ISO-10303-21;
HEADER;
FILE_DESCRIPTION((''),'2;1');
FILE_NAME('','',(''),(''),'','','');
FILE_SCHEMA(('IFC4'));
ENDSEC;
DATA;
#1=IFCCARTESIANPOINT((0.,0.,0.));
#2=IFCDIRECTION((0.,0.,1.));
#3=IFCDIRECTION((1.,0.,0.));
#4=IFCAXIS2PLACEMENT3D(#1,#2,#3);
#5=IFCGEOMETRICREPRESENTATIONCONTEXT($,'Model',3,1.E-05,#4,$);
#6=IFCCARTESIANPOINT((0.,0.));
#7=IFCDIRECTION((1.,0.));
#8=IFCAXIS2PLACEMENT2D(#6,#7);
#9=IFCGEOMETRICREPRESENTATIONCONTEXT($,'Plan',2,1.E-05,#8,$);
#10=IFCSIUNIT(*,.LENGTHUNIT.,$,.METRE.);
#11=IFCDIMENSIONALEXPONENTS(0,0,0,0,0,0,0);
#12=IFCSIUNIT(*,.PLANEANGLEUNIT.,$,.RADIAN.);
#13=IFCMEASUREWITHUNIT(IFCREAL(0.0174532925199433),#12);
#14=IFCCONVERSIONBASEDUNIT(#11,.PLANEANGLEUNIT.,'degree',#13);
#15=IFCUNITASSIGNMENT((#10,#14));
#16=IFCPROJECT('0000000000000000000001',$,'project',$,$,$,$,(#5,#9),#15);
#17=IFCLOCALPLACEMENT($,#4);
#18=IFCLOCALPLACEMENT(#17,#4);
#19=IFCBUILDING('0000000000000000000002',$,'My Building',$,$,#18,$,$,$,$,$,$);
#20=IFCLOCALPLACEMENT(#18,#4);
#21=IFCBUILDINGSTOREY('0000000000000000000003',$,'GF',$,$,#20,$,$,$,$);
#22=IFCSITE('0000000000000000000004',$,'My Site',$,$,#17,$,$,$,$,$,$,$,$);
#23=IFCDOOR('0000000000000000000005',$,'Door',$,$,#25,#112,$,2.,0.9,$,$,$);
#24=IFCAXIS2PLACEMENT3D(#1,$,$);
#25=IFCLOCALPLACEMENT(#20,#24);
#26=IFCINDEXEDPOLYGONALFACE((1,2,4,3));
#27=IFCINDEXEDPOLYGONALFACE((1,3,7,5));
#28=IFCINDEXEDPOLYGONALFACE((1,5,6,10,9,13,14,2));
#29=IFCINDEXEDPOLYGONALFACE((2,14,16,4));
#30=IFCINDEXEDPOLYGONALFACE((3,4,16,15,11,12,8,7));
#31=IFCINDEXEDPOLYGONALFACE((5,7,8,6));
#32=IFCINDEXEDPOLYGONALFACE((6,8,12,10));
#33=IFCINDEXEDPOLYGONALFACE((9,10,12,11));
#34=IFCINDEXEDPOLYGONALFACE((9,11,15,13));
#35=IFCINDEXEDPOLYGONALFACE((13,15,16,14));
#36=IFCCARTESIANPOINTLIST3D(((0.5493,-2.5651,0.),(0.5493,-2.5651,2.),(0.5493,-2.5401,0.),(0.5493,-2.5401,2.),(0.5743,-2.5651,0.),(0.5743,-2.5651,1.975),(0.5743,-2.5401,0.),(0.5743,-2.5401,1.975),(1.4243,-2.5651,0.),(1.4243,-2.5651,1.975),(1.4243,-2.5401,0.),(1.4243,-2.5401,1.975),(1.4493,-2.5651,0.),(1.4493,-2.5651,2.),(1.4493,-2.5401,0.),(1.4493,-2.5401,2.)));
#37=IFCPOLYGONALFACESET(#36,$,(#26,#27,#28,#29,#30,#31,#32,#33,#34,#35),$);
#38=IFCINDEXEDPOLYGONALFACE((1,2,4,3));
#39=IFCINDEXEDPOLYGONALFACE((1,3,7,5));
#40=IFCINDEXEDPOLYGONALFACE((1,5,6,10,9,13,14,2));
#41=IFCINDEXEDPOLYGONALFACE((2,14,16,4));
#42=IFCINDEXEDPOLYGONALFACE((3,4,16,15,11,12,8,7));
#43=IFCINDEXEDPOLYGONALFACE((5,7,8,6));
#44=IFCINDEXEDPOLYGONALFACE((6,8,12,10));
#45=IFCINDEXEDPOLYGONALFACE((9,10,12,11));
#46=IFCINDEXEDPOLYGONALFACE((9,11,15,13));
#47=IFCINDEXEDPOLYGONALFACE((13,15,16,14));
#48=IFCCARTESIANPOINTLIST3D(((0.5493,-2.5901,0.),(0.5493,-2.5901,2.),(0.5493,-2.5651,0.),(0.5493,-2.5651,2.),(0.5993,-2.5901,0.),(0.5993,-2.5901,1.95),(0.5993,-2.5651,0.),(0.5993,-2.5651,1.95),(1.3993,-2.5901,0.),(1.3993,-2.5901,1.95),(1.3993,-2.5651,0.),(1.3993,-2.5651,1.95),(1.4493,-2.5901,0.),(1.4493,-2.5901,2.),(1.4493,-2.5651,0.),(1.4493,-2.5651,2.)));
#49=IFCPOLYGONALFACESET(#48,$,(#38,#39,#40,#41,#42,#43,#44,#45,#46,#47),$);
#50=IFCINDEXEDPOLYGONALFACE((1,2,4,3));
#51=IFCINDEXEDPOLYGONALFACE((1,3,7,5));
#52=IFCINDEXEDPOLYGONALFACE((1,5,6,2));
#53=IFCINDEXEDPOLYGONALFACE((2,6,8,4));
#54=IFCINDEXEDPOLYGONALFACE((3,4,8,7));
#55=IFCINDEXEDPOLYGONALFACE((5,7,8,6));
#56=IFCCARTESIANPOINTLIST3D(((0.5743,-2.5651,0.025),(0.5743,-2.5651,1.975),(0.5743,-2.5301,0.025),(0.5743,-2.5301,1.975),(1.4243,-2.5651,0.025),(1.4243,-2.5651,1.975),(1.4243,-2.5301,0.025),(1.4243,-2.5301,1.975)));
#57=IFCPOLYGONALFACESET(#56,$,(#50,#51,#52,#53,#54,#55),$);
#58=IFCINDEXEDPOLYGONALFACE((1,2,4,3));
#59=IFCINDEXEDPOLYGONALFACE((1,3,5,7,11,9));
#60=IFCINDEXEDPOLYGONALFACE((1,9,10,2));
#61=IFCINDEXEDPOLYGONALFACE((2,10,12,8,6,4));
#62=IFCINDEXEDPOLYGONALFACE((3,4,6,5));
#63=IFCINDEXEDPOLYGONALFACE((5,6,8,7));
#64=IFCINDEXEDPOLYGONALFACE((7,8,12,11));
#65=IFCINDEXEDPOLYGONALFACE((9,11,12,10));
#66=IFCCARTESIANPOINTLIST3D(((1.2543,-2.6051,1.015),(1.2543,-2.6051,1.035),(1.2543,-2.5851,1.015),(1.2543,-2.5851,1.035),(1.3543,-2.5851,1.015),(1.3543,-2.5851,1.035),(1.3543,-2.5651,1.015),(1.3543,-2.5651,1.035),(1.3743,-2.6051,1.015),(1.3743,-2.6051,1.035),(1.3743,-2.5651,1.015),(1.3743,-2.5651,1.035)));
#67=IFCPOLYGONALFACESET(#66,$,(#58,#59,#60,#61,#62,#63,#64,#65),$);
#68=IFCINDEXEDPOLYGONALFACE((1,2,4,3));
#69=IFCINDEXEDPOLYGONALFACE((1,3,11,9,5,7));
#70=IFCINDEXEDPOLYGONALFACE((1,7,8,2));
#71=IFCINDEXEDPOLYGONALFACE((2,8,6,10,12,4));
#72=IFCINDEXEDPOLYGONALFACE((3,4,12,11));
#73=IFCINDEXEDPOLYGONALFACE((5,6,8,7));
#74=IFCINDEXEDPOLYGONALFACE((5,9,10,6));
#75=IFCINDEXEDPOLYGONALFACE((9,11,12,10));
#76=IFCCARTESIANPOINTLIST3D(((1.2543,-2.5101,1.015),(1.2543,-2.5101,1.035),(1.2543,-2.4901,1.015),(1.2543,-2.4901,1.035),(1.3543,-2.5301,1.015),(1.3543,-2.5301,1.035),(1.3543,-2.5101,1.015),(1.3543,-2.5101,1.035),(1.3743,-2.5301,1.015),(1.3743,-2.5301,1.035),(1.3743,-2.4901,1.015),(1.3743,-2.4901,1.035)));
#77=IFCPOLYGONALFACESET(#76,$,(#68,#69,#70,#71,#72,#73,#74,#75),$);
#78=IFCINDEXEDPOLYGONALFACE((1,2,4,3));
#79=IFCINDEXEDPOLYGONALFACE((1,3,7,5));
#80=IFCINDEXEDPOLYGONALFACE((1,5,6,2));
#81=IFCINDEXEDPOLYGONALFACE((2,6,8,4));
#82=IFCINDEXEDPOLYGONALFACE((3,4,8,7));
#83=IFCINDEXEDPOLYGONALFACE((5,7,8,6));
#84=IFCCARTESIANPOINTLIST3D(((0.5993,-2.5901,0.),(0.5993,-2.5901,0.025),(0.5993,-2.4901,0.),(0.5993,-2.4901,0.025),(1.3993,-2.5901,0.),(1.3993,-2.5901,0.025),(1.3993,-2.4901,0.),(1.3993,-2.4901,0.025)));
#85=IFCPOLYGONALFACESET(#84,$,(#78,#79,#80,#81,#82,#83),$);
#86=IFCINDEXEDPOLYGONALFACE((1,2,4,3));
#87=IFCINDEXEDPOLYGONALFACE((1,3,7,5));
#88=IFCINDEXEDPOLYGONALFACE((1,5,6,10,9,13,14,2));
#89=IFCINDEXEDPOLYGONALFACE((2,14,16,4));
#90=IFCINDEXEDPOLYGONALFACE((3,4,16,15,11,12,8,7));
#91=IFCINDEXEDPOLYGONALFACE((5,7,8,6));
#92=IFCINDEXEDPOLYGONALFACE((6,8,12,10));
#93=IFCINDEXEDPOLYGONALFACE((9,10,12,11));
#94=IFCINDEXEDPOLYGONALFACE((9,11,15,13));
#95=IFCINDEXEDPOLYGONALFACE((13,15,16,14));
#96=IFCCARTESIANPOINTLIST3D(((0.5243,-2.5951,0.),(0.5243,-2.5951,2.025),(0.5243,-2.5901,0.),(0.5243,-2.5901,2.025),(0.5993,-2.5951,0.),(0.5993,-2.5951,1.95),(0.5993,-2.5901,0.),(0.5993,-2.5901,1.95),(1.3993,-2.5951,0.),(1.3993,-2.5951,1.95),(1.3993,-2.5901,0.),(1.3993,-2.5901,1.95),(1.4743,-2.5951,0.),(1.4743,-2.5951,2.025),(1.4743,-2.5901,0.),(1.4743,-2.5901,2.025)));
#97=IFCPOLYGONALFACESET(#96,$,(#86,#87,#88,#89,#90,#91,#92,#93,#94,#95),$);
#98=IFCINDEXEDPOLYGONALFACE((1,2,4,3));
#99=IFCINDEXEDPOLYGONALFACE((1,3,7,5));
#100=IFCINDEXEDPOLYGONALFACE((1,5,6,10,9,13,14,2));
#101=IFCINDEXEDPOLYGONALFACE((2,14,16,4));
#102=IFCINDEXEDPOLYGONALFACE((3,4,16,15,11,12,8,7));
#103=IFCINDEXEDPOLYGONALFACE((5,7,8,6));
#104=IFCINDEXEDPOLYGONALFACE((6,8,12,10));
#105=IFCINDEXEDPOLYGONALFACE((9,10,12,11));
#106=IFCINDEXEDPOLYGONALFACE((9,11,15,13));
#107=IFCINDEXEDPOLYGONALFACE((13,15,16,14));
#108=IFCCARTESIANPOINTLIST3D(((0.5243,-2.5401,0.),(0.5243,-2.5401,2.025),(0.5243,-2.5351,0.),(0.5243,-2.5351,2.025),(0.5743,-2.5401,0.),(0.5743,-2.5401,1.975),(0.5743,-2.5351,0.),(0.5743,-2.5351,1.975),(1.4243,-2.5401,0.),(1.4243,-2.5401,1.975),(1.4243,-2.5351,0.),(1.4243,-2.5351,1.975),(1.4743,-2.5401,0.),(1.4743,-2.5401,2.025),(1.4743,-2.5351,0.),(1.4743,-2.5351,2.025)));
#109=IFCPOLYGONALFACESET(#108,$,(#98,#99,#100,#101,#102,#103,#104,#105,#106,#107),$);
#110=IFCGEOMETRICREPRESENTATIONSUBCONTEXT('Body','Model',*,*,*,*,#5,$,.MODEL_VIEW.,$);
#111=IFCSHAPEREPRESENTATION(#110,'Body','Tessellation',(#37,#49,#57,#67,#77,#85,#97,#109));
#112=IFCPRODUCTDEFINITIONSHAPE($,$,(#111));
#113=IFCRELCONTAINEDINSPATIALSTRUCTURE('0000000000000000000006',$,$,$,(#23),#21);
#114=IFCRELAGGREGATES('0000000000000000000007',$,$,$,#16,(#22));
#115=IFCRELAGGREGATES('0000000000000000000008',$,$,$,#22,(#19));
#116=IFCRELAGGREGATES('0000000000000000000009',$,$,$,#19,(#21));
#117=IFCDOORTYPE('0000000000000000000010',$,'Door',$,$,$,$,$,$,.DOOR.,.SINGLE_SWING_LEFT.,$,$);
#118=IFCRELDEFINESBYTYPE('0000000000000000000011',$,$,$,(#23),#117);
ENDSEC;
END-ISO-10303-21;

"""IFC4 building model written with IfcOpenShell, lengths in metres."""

from ifc_helpers import new_model, entity, si_unit, converted_unit, frame, origin_with_axes, origin_2d_with_axis, place, context, subcontext, project, spatial, line, indexed_curve, outline, extrude, shape, source, transform, mapped, type_object, type_shapes, element, save


model = new_model("IFC4")

# Units and contexts
model_context = context("Model", 3, precision=1e-05, world=origin_with_axes())
plan_context = context("Plan", 2, precision=1e-05, world=origin_2d_with_axis())
body_context_1 = subcontext(model_context, "Body", "Model", "MODEL_VIEW")
body_context_2 = subcontext(plan_context, "Body", "Plan", "PLAN_VIEW")
ifc_project = project(units=[si_unit("LENGTHUNIT", "METRE"), converted_unit("PLANEANGLEUNIT", "degree", entity("IfcReal", 0.0174532925199433), si_unit("PLANEANGLEUNIT", "RADIAN"), dimensions=[0, 0, 0, 0, 0, 0, 0])], contexts=[model_context, plan_context])

# Site, building, storey
site_placement = place(None, origin_with_axes())
site = spatial("IfcSite", under=ifc_project, at=site_placement, Name="My Site")
building_placement = place(site_placement, origin_with_axes())
building = spatial("IfcBuilding", under=site, at=building_placement, Name="My Building")
storey_placement = place(building_placement, origin_with_axes())
storey = spatial("IfcBuildingStorey", under=building, at=storey_placement, Name="GF")

# Shared definitions
door_type = type_object("IfcDoorType", Name="Door", OperationType="SINGLE_SWING_LEFT", PredefinedType="DOOR")
shared_shape_1 = source(origin_with_axes(), body_context_1, "Body", "SweptSolid", [
    extrude(outline(indexed_curve([(0.0, 0.0), (0.0, 2.0), (0.9, 2.0), (0.9, 0.0), (0.875, 0.0), (0.875, 1.975), (0.025, 1.975), (0.025, 0.0)], segments=[line(1, 2, 3, 4, 5, 6, 7, 8, 1)])), frame((0.0, 0.025, 0.0), z_axis=(0.0, -1.0, 0.0), x_axis=(1.0, 0.0, 0.0)), (0.0, 0.0, -1.0), 0.025),
    extrude(outline(indexed_curve([(0.0, 0.0), (0.0, 2.0), (0.9, 2.0), (0.9, 0.0), (0.85, 0.0), (0.85, 1.95), (0.05, 1.95), (0.05, 0.0)], segments=[line(1, 2, 3, 4, 5, 6, 7, 8, 1)])), frame((0.0, 0.0, 0.0), z_axis=(0.0, -1.0, 0.0), x_axis=(1.0, 0.0, 0.0)), (0.0, 0.0, -1.0), 0.025),
    extrude(outline(indexed_curve([(0.0, 0.0), (0.85, 0.0), (0.85, 0.035), (0.0, 0.035)], segments=[line(1, 2, 3, 4, 1)])), frame((0.025, 0.025, 0.025), z_axis=(0.0, 0.0, 1.0), x_axis=(1.0, 0.0, 0.0)), (0.0, 0.0, 1.0), 1.95),
    extrude(outline(indexed_curve([(0.0, 0.0), (0.0, -0.04), (-0.12, -0.04), (-0.12, -0.02), (-0.02, -0.02), (-0.02, 0.0)], segments=[line(1, 2, 3, 4, 5, 6, 1)])), frame((0.825, 0.025, 1.015), z_axis=(0.0, 0.0, 1.0), x_axis=(1.0, 0.0, 0.0)), (0.0, 0.0, 1.0), 0.02),
    extrude(outline(indexed_curve([(0.0, 0.0), (0.0, 0.04), (-0.12, 0.04), (-0.12, 0.02), (-0.02, 0.02), (-0.02, 0.0)], segments=[line(1, 2, 3, 4, 5, 6, 1)])), frame((0.825, 0.06, 1.015), z_axis=(0.0, 0.0, 1.0), x_axis=(1.0, 0.0, 0.0)), (0.0, 0.0, 1.0), 0.02),
    extrude(outline(indexed_curve([(0.0, 0.0), (0.8, 0.0), (0.8, 0.1), (0.0, 0.1)], segments=[line(1, 2, 3, 4, 1)])), frame((0.05, 0.0, 0.0), z_axis=(0.0, 0.0, 1.0), x_axis=(1.0, 0.0, 0.0)), (0.0, 0.0, 1.0), 0.025),
    extrude(outline(indexed_curve([(0.0, 0.0), (0.0, 2.025), (0.95, 2.025), (0.95, 0.0), (0.875, 0.0), (0.875, 1.95), (0.075, 1.95), (0.075, 0.0)], segments=[line(1, 2, 3, 4, 5, 6, 7, 8, 1)])), frame((-0.025, -0.005, 0.0), z_axis=(0.0, -1.0, 0.0), x_axis=(1.0, 0.0, 0.0)), (0.0, 0.0, -1.0), 0.005),
    extrude(outline(indexed_curve([(0.0, 0.0), (0.0, 2.025), (0.95, 2.025), (0.95, 0.0), (0.9, 0.0), (0.9, 1.975), (0.05, 1.975), (0.05, 0.0)], segments=[line(1, 2, 3, 4, 5, 6, 7, 8, 1)])), frame((-0.025, 0.05, 0.0), z_axis=(0.0, -1.0, 0.0), x_axis=(1.0, 0.0, 0.0)), (0.0, 0.0, -1.0), 0.005),
])
shared_shape_2 = source(origin_with_axes(), body_context_2, "Body", "Curve2D", [
    entity("IfcIndexedPolyCurve", entity("IfcCartesianPointList2D", [[0.0, 0.0], [0.0, 0.05], [0.025, 0.05], [0.025, 0.025], [0.05, 0.025], [0.05, 0.0]]), [entity("IfcLineIndex", [1, 2, 3, 4, 5, 6, 1])]),
    entity("IfcIndexedPolyCurve", entity("IfcCartesianPointList2D", [[0.9, 0.0], [0.9, 0.05], [0.875, 0.05], [0.875, 0.025], [0.85, 0.025], [0.85, 0.0]]), [entity("IfcLineIndex", [1, 2, 3, 4, 5, 6, 1])]),
    entity("IfcTrimmedCurve", entity("IfcEllipse", entity("IfcAxis2Placement2D", entity("IfcCartesianPoint", [0.06, 0.05]), entity("IfcDirection", [1.0, 0.0])), 0.815, 0.85), [entity("IfcCartesianPoint", [0.875, 0.05])], [entity("IfcCartesianPoint", [0.06, 0.9])], True, "CARTESIAN"),
    entity("IfcIndexedPolyCurve", entity("IfcCartesianPointList2D", [[0.025, 0.05], [0.06, 0.05], [0.06, 0.9], [0.025, 0.9]]), [entity("IfcLineIndex", [1, 2, 3, 4, 1])]),
])
type_shapes(door_type, [shared_shape_1, shared_shape_2])

# Door
door_1_placement = place(storey_placement, frame((0.5493, -2.5901, 0.0), z_axis=(0.0, 0.0, 1.0), x_axis=(1.0, 0.0, 0.0)))
element("IfcDoor", 1, at=door_1_placement, inside=storey, type_object=door_type, Name="Door", OverallHeight=2.0, OverallWidth=0.9, shapes=[
    shape(body_context_1, "Body", "MappedRepresentation", [mapped(shared_shape_1, transform((0.0, 0.0, 0.0), x_axis=(1.0, 0.0, 0.0), y_axis=(0.0, 1.0, 0.0), z_axis=(0.0, 0.0, 1.0), scale=1.0))]),
    shape(body_context_2, "Body", "MappedRepresentation", [mapped(shared_shape_2, transform((0.0, 0.0, 0.0), x_axis=(1.0, 0.0, 0.0), y_axis=(0.0, 1.0, 0.0), z_axis=(0.0, 0.0, 1.0), scale=1.0))]),
])

save(model, "model.ifc")
